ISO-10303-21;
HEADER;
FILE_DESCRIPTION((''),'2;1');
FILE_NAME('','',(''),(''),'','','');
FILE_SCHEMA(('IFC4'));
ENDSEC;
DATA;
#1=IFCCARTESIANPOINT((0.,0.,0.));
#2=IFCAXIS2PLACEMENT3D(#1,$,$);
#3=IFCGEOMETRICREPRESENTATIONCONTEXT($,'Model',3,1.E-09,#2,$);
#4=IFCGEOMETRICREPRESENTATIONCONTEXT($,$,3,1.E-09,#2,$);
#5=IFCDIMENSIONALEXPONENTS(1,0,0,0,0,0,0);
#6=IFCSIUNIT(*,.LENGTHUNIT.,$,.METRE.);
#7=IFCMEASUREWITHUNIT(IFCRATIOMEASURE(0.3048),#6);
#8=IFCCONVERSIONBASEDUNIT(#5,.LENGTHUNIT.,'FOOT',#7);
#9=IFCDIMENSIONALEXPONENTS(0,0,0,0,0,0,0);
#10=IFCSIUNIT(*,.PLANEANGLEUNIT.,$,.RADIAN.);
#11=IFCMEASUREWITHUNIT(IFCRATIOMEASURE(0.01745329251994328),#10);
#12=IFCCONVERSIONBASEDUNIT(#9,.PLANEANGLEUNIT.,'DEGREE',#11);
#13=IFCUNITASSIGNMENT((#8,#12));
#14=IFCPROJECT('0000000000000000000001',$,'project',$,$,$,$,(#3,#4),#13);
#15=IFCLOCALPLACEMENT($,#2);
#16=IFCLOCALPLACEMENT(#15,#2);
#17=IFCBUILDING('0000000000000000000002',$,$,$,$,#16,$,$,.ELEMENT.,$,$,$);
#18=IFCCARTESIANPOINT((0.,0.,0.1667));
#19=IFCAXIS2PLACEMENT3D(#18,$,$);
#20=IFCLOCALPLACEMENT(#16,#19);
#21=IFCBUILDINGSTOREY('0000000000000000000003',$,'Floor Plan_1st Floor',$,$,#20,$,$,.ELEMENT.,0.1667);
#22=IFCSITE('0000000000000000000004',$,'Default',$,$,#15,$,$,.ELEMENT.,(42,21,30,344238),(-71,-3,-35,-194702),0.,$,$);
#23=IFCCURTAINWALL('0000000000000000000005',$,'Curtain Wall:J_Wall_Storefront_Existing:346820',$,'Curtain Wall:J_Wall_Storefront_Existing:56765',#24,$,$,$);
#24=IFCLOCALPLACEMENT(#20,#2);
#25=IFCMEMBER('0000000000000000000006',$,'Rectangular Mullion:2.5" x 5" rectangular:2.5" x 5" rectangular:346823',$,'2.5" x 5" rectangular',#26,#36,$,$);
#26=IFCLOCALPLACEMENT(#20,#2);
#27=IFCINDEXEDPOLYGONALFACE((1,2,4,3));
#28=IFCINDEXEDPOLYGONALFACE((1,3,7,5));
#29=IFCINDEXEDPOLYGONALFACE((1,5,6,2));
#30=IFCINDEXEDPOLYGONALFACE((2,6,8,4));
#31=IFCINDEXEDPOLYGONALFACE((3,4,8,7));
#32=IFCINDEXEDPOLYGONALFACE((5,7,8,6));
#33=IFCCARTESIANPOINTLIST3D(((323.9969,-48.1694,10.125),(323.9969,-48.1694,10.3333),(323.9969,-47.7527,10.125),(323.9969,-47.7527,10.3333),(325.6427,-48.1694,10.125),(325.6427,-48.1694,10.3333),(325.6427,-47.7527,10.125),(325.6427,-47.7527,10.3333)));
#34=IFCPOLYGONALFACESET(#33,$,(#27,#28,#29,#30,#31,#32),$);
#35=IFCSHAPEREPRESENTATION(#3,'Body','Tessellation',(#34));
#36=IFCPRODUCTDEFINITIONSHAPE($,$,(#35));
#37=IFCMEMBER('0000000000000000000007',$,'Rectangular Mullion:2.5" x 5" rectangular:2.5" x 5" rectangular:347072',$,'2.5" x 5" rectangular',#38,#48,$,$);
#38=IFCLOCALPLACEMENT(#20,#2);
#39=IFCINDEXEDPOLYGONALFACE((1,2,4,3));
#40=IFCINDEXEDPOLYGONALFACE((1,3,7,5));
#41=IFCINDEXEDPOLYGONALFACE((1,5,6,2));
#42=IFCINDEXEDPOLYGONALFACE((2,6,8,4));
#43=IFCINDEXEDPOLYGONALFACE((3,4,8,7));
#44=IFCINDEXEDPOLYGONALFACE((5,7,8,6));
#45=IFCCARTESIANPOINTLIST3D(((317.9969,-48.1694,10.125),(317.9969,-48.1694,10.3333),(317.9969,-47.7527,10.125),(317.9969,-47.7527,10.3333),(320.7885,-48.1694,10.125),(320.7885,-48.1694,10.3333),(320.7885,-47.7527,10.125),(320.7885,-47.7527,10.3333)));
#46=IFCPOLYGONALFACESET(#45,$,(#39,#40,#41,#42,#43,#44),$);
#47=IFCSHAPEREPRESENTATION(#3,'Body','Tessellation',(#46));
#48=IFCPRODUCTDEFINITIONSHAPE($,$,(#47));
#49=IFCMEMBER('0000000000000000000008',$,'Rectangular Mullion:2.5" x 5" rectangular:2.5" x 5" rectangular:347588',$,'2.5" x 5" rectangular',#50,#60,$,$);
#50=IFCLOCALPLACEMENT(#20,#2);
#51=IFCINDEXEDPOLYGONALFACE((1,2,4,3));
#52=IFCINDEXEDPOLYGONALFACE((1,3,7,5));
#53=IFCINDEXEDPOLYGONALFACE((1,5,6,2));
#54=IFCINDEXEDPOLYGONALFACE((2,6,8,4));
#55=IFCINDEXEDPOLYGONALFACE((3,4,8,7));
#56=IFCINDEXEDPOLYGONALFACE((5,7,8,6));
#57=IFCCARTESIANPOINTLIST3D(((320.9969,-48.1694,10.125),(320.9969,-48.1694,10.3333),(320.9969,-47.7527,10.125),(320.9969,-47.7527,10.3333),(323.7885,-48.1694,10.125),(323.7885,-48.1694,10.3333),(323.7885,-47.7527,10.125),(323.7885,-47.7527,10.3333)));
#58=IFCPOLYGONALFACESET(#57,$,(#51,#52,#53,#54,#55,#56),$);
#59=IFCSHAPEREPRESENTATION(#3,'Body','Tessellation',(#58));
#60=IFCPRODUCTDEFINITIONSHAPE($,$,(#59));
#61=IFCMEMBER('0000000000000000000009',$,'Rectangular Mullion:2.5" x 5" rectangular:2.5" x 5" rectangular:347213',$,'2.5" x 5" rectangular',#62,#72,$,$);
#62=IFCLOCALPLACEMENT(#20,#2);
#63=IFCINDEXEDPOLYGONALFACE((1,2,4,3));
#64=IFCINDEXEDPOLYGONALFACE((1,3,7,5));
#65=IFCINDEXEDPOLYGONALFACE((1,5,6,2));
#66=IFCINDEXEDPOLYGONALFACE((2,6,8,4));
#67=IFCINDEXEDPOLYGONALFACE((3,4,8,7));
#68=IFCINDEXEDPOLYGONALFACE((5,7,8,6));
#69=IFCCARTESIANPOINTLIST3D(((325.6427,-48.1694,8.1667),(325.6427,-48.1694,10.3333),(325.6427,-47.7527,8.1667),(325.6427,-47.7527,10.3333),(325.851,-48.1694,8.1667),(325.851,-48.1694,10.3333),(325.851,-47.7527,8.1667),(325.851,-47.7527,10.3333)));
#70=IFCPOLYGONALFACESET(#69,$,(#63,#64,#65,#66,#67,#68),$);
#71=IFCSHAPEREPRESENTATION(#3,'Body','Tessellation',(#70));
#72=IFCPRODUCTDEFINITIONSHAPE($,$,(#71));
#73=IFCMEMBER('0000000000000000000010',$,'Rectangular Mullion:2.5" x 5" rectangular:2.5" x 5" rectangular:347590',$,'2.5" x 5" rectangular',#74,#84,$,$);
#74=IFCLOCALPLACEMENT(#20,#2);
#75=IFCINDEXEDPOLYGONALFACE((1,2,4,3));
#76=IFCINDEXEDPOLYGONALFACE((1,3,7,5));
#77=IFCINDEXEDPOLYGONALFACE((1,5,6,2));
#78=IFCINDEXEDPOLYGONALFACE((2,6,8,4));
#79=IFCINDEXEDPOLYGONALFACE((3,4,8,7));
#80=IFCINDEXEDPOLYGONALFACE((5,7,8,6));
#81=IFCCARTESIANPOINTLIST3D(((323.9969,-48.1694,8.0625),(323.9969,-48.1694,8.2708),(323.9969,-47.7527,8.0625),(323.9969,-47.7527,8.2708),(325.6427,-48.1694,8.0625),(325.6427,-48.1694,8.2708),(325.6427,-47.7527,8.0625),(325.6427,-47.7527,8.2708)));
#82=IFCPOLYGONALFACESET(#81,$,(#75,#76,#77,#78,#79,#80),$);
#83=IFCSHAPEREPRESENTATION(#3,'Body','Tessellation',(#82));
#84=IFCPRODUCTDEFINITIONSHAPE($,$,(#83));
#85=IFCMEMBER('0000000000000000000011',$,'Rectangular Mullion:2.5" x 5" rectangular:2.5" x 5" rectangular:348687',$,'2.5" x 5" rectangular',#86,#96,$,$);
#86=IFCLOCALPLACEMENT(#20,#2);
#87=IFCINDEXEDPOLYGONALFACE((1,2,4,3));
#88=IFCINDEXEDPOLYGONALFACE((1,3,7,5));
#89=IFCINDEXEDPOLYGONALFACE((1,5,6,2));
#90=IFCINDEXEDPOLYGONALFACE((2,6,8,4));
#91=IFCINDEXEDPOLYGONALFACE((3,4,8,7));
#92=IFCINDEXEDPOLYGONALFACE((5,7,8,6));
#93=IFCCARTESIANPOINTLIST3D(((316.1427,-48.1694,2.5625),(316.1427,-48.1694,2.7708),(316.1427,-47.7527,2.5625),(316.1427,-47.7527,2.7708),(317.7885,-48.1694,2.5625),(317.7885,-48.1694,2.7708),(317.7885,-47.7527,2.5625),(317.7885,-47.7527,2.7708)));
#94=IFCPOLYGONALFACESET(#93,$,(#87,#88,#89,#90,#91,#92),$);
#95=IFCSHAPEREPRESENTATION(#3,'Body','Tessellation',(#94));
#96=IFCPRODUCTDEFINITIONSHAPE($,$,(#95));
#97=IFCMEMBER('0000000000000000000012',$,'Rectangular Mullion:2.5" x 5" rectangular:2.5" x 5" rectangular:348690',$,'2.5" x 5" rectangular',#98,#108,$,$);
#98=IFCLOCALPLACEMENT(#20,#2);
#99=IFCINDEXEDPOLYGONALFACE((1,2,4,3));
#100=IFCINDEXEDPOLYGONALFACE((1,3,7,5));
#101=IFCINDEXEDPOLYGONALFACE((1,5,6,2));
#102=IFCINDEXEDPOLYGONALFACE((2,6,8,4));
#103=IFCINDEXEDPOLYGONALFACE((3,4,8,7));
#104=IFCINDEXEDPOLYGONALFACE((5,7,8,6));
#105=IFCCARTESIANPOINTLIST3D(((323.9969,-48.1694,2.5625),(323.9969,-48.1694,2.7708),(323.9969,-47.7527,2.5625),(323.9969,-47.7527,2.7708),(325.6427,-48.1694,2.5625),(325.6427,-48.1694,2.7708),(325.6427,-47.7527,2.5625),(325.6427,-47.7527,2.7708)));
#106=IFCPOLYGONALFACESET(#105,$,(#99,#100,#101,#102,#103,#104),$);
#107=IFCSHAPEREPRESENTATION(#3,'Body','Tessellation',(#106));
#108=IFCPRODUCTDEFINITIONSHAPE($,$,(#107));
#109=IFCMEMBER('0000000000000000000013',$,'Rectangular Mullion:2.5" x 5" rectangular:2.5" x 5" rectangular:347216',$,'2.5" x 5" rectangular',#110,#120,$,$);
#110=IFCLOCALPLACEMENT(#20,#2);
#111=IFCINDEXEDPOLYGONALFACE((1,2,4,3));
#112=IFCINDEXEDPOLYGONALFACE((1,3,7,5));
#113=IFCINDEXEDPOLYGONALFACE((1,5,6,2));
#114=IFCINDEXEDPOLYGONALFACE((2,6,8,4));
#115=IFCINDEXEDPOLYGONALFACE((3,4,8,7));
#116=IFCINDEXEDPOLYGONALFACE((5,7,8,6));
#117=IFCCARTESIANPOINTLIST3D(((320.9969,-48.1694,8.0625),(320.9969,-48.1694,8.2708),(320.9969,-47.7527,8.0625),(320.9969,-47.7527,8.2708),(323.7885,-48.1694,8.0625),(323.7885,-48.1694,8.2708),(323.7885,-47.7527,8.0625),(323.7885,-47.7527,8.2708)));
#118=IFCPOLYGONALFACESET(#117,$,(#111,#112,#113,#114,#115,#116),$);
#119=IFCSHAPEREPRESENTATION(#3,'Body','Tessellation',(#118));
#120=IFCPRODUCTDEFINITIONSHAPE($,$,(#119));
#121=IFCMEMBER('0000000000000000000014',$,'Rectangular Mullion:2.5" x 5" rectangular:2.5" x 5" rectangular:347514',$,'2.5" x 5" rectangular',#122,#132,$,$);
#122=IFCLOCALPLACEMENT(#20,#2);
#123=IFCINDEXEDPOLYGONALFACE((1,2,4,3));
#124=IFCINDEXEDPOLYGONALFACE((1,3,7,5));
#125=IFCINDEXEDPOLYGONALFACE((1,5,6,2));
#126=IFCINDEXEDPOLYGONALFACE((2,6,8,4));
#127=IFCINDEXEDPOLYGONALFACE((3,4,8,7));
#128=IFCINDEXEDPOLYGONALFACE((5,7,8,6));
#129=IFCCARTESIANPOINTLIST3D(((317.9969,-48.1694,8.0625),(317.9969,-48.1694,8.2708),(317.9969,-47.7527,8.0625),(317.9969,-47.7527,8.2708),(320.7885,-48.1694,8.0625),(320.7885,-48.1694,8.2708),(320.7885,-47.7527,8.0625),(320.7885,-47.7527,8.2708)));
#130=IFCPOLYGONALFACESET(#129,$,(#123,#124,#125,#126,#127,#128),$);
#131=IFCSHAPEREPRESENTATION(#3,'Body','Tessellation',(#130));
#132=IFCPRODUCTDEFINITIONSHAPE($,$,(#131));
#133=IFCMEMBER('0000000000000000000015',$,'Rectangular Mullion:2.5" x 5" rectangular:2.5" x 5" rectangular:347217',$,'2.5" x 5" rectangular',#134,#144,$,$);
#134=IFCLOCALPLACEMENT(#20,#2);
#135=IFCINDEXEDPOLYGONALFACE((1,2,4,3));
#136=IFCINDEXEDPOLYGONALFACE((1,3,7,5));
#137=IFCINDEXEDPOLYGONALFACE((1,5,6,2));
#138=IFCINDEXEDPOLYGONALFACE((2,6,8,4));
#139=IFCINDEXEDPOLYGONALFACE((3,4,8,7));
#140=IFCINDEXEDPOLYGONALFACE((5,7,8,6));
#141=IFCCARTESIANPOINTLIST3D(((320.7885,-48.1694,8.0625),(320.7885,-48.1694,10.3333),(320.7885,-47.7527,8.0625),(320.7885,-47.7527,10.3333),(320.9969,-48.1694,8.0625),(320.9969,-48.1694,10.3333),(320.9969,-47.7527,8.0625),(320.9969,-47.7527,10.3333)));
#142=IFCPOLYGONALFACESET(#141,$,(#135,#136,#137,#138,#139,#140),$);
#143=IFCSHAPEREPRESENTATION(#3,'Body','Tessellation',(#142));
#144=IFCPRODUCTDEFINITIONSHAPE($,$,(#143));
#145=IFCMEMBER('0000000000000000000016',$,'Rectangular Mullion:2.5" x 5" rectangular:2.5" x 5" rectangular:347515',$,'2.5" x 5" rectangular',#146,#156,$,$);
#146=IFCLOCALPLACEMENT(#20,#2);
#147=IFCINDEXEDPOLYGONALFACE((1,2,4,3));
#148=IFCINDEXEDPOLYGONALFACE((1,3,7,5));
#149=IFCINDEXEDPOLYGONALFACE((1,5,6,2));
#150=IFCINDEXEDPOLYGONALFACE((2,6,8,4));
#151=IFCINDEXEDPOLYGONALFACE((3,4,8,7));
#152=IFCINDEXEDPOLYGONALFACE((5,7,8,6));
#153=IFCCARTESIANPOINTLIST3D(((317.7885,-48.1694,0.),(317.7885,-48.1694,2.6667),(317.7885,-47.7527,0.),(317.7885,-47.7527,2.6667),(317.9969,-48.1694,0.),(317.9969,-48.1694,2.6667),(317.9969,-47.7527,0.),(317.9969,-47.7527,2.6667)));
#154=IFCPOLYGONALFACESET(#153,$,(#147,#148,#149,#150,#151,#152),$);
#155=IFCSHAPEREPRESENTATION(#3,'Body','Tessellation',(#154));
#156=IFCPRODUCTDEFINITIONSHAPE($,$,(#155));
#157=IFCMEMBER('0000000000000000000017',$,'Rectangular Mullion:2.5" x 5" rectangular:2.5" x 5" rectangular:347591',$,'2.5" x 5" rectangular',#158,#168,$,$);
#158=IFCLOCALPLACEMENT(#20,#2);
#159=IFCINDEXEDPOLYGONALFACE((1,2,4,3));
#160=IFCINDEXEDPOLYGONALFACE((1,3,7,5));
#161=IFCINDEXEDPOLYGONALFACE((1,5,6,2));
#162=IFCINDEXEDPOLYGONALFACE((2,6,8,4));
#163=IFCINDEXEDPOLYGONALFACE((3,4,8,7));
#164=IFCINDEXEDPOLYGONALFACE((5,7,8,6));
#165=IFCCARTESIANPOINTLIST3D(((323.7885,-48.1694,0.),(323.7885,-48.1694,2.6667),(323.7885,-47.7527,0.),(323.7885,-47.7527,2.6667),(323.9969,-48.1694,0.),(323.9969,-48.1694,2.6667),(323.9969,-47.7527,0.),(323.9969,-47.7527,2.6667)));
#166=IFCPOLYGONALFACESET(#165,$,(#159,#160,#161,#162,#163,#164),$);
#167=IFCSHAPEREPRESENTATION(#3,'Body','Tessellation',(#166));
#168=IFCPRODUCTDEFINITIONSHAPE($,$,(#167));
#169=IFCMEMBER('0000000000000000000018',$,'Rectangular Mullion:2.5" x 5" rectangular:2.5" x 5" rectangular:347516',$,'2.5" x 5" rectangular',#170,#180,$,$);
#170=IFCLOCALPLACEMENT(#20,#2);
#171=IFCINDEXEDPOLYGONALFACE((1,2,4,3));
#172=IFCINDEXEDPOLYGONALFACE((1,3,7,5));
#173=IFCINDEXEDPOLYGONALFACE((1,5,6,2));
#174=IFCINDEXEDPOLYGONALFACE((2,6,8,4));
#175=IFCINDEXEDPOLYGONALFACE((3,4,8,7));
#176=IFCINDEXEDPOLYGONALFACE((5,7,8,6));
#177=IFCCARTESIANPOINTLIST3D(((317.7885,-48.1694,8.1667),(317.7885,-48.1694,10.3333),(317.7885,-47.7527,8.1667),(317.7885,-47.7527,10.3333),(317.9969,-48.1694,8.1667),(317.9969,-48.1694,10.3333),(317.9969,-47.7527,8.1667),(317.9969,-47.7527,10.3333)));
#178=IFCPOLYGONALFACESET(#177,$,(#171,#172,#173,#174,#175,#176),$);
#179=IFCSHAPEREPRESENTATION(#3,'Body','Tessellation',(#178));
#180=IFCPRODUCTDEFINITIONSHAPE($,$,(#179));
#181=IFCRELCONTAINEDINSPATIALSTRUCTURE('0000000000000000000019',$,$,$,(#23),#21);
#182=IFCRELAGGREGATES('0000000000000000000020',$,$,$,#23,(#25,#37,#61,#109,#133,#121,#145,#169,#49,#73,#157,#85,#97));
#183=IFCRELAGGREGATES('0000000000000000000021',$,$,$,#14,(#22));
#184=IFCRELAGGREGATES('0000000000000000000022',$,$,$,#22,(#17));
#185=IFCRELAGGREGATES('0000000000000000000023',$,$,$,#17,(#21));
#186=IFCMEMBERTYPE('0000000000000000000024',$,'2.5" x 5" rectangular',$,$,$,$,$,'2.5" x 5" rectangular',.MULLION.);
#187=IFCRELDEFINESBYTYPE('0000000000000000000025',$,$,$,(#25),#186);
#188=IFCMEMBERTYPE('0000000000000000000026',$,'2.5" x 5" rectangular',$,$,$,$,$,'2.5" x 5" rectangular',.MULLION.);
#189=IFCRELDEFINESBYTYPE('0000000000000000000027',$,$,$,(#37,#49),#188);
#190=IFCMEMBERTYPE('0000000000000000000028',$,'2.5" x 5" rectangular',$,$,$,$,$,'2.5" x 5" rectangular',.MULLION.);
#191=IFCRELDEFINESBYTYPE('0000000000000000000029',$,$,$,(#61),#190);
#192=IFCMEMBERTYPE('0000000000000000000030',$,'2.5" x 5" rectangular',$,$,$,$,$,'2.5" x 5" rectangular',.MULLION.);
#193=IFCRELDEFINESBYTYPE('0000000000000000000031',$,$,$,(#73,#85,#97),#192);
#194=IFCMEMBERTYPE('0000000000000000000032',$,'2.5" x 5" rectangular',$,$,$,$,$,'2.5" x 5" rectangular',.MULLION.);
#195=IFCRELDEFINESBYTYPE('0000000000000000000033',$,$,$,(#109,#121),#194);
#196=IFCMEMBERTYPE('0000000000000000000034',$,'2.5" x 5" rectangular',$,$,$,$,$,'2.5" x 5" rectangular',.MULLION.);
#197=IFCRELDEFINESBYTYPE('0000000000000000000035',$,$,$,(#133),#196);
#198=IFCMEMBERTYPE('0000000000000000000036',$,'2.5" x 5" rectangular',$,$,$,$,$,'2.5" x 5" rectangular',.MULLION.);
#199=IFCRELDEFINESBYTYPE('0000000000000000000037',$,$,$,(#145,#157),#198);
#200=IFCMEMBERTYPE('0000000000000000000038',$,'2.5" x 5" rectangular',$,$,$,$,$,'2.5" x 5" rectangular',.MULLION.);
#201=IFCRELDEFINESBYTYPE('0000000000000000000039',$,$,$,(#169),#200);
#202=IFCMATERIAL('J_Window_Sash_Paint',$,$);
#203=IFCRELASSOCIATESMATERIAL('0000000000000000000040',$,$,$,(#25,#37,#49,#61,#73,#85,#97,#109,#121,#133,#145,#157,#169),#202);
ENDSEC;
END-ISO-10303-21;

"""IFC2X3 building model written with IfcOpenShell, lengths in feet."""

from ifc_helpers import new_model, entity, si_unit, converted_unit, frame, origin, origin_2d_with_axis, place, context, project, spatial, rectangle, extrude, source, transform, mapped, material, type_object, type_shapes, element, aggregate, save


model = new_model("IFC2X3")

# Units and contexts
model_context = context("Model", 3, precision=1e-09, world=origin())
context_of_model = context(None, 3, precision=1e-09, world=origin())
ifc_project = project(units=[converted_unit("LENGTHUNIT", "FOOT", entity("IfcRatioMeasure", 0.3048), si_unit("LENGTHUNIT", "METRE"), dimensions=[1, 0, 0, 0, 0, 0, 0]), converted_unit("PLANEANGLEUNIT", "DEGREE", entity("IfcRatioMeasure", 0.01745329251994328), si_unit("PLANEANGLEUNIT", "RADIAN"), dimensions=[0, 0, 0, 0, 0, 0, 0])], contexts=[model_context, context_of_model])

# Site, building, storey
site_placement = place(None, origin())
site = spatial("IfcSite", under=ifc_project, at=site_placement, Name="Default", CompositionType="ELEMENT", RefLatitude=(42, 21, 30, 344238), RefLongitude=(-71, -3, -35, -194702), RefElevation=0.0)
building_placement = place(site_placement, origin())
building = spatial("IfcBuilding", under=site, at=building_placement, CompositionType="ELEMENT")
storey_placement = place(building_placement, frame((0.0, 0.0, 0.1667)))
storey = spatial("IfcBuildingStorey", under=building, at=storey_placement, Name="Floor Plan_1st Floor", CompositionType="ELEMENT", Elevation=0.1667)

# Curtain wall, members
curtain_wall_placement = place(storey_placement, origin())
curtain_wall = element("IfcCurtainWall", 1, at=curtain_wall_placement, inside=storey, Name="Curtain Wall:J_Wall_Storefront_Existing:346820", ObjectType="Curtain Wall:J_Wall_Storefront_Existing:56765")
ifc_material_1 = material(Name="J_Window_Sash_Paint")
member_type_1 = type_object("IfcMemberType", Name="2.5\" x 5\" rectangular", ElementType="2.5\" x 5\" rectangular", PredefinedType="MULLION")
shared_shape_1 = source(origin(), model_context, "Body", "SweptSolid", [
    extrude(rectangle(XDim=0.2083, YDim=0.4167, at=origin_2d_with_axis()), frame((-0.1042, 0.0, -1.6458), z_axis=(0.0, 0.0, 1.0), x_axis=(-1.0, 0.0, 0.0)), (0.0, 0.0, 1.0), 1.6458),
])
type_shapes(member_type_1, [shared_shape_1])
member_1_placement = place(storey_placement, frame((325.6427, -47.9611, 10.3333), z_axis=(1.0, 0.0, 0.0), x_axis=(0.0, 0.0, 1.0)))
member_1 = element("IfcMember", 2, at=member_1_placement, type_object=member_type_1, material=ifc_material_1, Name="Rectangular Mullion:2.5\" x 5\" rectangular:2.5\" x 5\" rectangular:346823", ObjectType="2.5\" x 5\" rectangular", context=model_context, shape_type="MappedRepresentation", body=[
    mapped(shared_shape_1, transform((0.0, 0.0, 0.0), scale=1.0)),
])
member_type_2 = type_object("IfcMemberType", Name="2.5\" x 5\" rectangular", ElementType="2.5\" x 5\" rectangular", PredefinedType="MULLION")
shared_shape_2 = source(origin(), model_context, "Body", "SweptSolid", [
    extrude(rectangle(XDim=0.2083, YDim=0.4167, at=origin_2d_with_axis()), frame((-0.1042, 0.0, -2.7917), z_axis=(0.0, 0.0, 1.0), x_axis=(-1.0, 0.0, 0.0)), (0.0, 0.0, 1.0), 2.7917),
])
type_shapes(member_type_2, [shared_shape_2])
member_2_placement = place(storey_placement, frame((320.7885, -47.9611, 10.3333), z_axis=(1.0, 0.0, 0.0), x_axis=(0.0, 0.0, 1.0)))
member_2 = element("IfcMember", 3, at=member_2_placement, type_object=member_type_2, material=ifc_material_1, Name="Rectangular Mullion:2.5\" x 5\" rectangular:2.5\" x 5\" rectangular:347072", ObjectType="2.5\" x 5\" rectangular", context=model_context, shape_type="MappedRepresentation", body=[
    mapped(shared_shape_2, transform((0.0, 0.0, 0.0), scale=1.0)),
])
member_3_placement = place(storey_placement, frame((323.7885, -47.9611, 10.3333), z_axis=(1.0, 0.0, 0.0), x_axis=(0.0, 0.0, 1.0)))
member_3 = element("IfcMember", 4, at=member_3_placement, type_object=member_type_2, material=ifc_material_1, Name="Rectangular Mullion:2.5\" x 5\" rectangular:2.5\" x 5\" rectangular:347588", ObjectType="2.5\" x 5\" rectangular", context=model_context, shape_type="MappedRepresentation", body=[
    mapped(shared_shape_2, transform((0.0, 0.0, 0.0), scale=1.0)),
])
member_type_3 = type_object("IfcMemberType", Name="2.5\" x 5\" rectangular", ElementType="2.5\" x 5\" rectangular", PredefinedType="MULLION")
shared_shape_3 = source(origin(), model_context, "Body", "SweptSolid", [
    extrude(rectangle(XDim=0.2083, YDim=0.4167, at=origin_2d_with_axis()), frame((-0.1042, 0.0, -2.1667), z_axis=(0.0, 0.0, 1.0), x_axis=(-1.0, 0.0, 0.0)), (0.0, 0.0, 1.0), 2.1667),
])
type_shapes(member_type_3, [shared_shape_3])
member_4_placement = place(storey_placement, frame((325.851, -47.9611, 8.1667), z_axis=(0.0, 0.0, -1.0), x_axis=(1.0, 0.0, 0.0)))
member_4 = element("IfcMember", 5, at=member_4_placement, type_object=member_type_3, material=ifc_material_1, Name="Rectangular Mullion:2.5\" x 5\" rectangular:2.5\" x 5\" rectangular:347213", ObjectType="2.5\" x 5\" rectangular", context=model_context, shape_type="MappedRepresentation", body=[
    mapped(shared_shape_3, transform((0.0, 0.0, 0.0), scale=1.0)),
])
member_type_4 = type_object("IfcMemberType", Name="2.5\" x 5\" rectangular", ElementType="2.5\" x 5\" rectangular", PredefinedType="MULLION")
shared_shape_4 = source(origin(), model_context, "Body", "SweptSolid", [
    extrude(rectangle(XDim=0.2083, YDim=0.4167, at=origin_2d_with_axis()), frame((0.0, 0.0, -1.6458), z_axis=(0.0, 0.0, 1.0), x_axis=(-1.0, 0.0, 0.0)), (0.0, 0.0, 1.0), 1.6458),
])
type_shapes(member_type_4, [shared_shape_4])
member_5_placement = place(storey_placement, frame((325.6427, -47.9611, 8.1667), z_axis=(1.0, 0.0, 0.0), x_axis=(0.0, 0.0, 1.0)))
member_5 = element("IfcMember", 6, at=member_5_placement, type_object=member_type_4, material=ifc_material_1, Name="Rectangular Mullion:2.5\" x 5\" rectangular:2.5\" x 5\" rectangular:347590", ObjectType="2.5\" x 5\" rectangular", context=model_context, shape_type="MappedRepresentation", body=[
    mapped(shared_shape_4, transform((0.0, 0.0, 0.0), scale=1.0)),
])
member_6_placement = place(storey_placement, frame((317.7885, -47.9611, 2.6667), z_axis=(1.0, 0.0, 0.0), x_axis=(0.0, 0.0, 1.0)))
member_6 = element("IfcMember", 7, at=member_6_placement, type_object=member_type_4, material=ifc_material_1, Name="Rectangular Mullion:2.5\" x 5\" rectangular:2.5\" x 5\" rectangular:348687", ObjectType="2.5\" x 5\" rectangular", context=model_context, shape_type="MappedRepresentation", body=[
    mapped(shared_shape_4, transform((0.0, 0.0, 0.0), scale=1.0)),
])
member_7_placement = place(storey_placement, frame((325.6427, -47.9611, 2.6667), z_axis=(1.0, 0.0, 0.0), x_axis=(0.0, 0.0, 1.0)))
member_7 = element("IfcMember", 8, at=member_7_placement, type_object=member_type_4, material=ifc_material_1, Name="Rectangular Mullion:2.5\" x 5\" rectangular:2.5\" x 5\" rectangular:348690", ObjectType="2.5\" x 5\" rectangular", context=model_context, shape_type="MappedRepresentation", body=[
    mapped(shared_shape_4, transform((0.0, 0.0, 0.0), scale=1.0)),
])
member_type_5 = type_object("IfcMemberType", Name="2.5\" x 5\" rectangular", ElementType="2.5\" x 5\" rectangular", PredefinedType="MULLION")
shared_shape_5 = source(origin(), model_context, "Body", "SweptSolid", [
    extrude(rectangle(XDim=0.2083, YDim=0.4167, at=origin_2d_with_axis()), frame((0.0, 0.0, -2.7917), z_axis=(0.0, 0.0, 1.0), x_axis=(-1.0, 0.0, 0.0)), (0.0, 0.0, 1.0), 2.7917),
])
type_shapes(member_type_5, [shared_shape_5])
member_8_placement = place(storey_placement, frame((323.7885, -47.9611, 8.1667), z_axis=(1.0, 0.0, 0.0), x_axis=(0.0, 0.0, 1.0)))
member_8 = element("IfcMember", 9, at=member_8_placement, type_object=member_type_5, material=ifc_material_1, Name="Rectangular Mullion:2.5\" x 5\" rectangular:2.5\" x 5\" rectangular:347216", ObjectType="2.5\" x 5\" rectangular", context=model_context, shape_type="MappedRepresentation", body=[
    mapped(shared_shape_5, transform((0.0, 0.0, 0.0), scale=1.0)),
])
member_9_placement = place(storey_placement, frame((320.7885, -47.9611, 8.1667), z_axis=(1.0, 0.0, 0.0), x_axis=(0.0, 0.0, 1.0)))
member_9 = element("IfcMember", 10, at=member_9_placement, type_object=member_type_5, material=ifc_material_1, Name="Rectangular Mullion:2.5\" x 5\" rectangular:2.5\" x 5\" rectangular:347514", ObjectType="2.5\" x 5\" rectangular", context=model_context, shape_type="MappedRepresentation", body=[
    mapped(shared_shape_5, transform((0.0, 0.0, 0.0), scale=1.0)),
])
member_type_6 = type_object("IfcMemberType", Name="2.5\" x 5\" rectangular", ElementType="2.5\" x 5\" rectangular", PredefinedType="MULLION")
shared_shape_6 = source(origin(), model_context, "Body", "SweptSolid", [
    extrude(rectangle(XDim=0.2083, YDim=0.4167, at=origin_2d_with_axis()), frame((0.0, 0.0, -2.2708), z_axis=(0.0, 0.0, 1.0), x_axis=(-1.0, 0.0, 0.0)), (0.0, 0.0, 1.0), 2.2708),
])
type_shapes(member_type_6, [shared_shape_6])
member_10_placement = place(storey_placement, frame((320.8927, -47.9611, 8.0625), z_axis=(0.0, 0.0, -1.0), x_axis=(1.0, 0.0, 0.0)))
member_10 = element("IfcMember", 11, at=member_10_placement, type_object=member_type_6, material=ifc_material_1, Name="Rectangular Mullion:2.5\" x 5\" rectangular:2.5\" x 5\" rectangular:347217", ObjectType="2.5\" x 5\" rectangular", context=model_context, shape_type="MappedRepresentation", body=[
    mapped(shared_shape_6, transform((0.0, 0.0, 0.0), scale=1.0)),
])
member_type_7 = type_object("IfcMemberType", Name="2.5\" x 5\" rectangular", ElementType="2.5\" x 5\" rectangular", PredefinedType="MULLION")
shared_shape_7 = source(origin(), model_context, "Body", "SweptSolid", [
    extrude(rectangle(XDim=0.2083, YDim=0.4167, at=origin_2d_with_axis()), frame((0.0, 0.0, -2.6667), z_axis=(0.0, 0.0, 1.0), x_axis=(-1.0, 0.0, 0.0)), (0.0, 0.0, 1.0), 2.6667),
])
type_shapes(member_type_7, [shared_shape_7])
member_11_placement = place(storey_placement, frame((317.8927, -47.9611, 0.0), z_axis=(0.0, 0.0, -1.0), x_axis=(1.0, 0.0, 0.0)))
member_11 = element("IfcMember", 12, at=member_11_placement, type_object=member_type_7, material=ifc_material_1, Name="Rectangular Mullion:2.5\" x 5\" rectangular:2.5\" x 5\" rectangular:347515", ObjectType="2.5\" x 5\" rectangular", context=model_context, shape_type="MappedRepresentation", body=[
    mapped(shared_shape_7, transform((0.0, 0.0, 0.0), scale=1.0)),
])
member_12_placement = place(storey_placement, frame((323.8927, -47.9611, 0.0), z_axis=(0.0, 0.0, -1.0), x_axis=(1.0, 0.0, 0.0)))
member_12 = element("IfcMember", 13, at=member_12_placement, type_object=member_type_7, material=ifc_material_1, Name="Rectangular Mullion:2.5\" x 5\" rectangular:2.5\" x 5\" rectangular:347591", ObjectType="2.5\" x 5\" rectangular", context=model_context, shape_type="MappedRepresentation", body=[
    mapped(shared_shape_7, transform((0.0, 0.0, 0.0), scale=1.0)),
])
member_type_8 = type_object("IfcMemberType", Name="2.5\" x 5\" rectangular", ElementType="2.5\" x 5\" rectangular", PredefinedType="MULLION")
shared_shape_8 = source(origin(), model_context, "Body", "SweptSolid", [
    extrude(rectangle(XDim=0.2083, YDim=0.4167, at=origin_2d_with_axis()), frame((0.0, 0.0, -2.1667), z_axis=(0.0, 0.0, 1.0), x_axis=(-1.0, 0.0, 0.0)), (0.0, 0.0, 1.0), 2.1667),
])
type_shapes(member_type_8, [shared_shape_8])
member_13_placement = place(storey_placement, frame((317.8927, -47.9611, 8.1667), z_axis=(0.0, 0.0, -1.0), x_axis=(1.0, 0.0, 0.0)))
member_13 = element("IfcMember", 14, at=member_13_placement, type_object=member_type_8, material=ifc_material_1, Name="Rectangular Mullion:2.5\" x 5\" rectangular:2.5\" x 5\" rectangular:347516", ObjectType="2.5\" x 5\" rectangular", context=model_context, shape_type="MappedRepresentation", body=[
    mapped(shared_shape_8, transform((0.0, 0.0, 0.0), scale=1.0)),
])
aggregate(curtain_wall, [member_1, member_2, member_4, member_8, member_10, member_9, member_11, member_13, member_3, member_5, member_12, member_6, member_7])

save(model, "model.ifc")
